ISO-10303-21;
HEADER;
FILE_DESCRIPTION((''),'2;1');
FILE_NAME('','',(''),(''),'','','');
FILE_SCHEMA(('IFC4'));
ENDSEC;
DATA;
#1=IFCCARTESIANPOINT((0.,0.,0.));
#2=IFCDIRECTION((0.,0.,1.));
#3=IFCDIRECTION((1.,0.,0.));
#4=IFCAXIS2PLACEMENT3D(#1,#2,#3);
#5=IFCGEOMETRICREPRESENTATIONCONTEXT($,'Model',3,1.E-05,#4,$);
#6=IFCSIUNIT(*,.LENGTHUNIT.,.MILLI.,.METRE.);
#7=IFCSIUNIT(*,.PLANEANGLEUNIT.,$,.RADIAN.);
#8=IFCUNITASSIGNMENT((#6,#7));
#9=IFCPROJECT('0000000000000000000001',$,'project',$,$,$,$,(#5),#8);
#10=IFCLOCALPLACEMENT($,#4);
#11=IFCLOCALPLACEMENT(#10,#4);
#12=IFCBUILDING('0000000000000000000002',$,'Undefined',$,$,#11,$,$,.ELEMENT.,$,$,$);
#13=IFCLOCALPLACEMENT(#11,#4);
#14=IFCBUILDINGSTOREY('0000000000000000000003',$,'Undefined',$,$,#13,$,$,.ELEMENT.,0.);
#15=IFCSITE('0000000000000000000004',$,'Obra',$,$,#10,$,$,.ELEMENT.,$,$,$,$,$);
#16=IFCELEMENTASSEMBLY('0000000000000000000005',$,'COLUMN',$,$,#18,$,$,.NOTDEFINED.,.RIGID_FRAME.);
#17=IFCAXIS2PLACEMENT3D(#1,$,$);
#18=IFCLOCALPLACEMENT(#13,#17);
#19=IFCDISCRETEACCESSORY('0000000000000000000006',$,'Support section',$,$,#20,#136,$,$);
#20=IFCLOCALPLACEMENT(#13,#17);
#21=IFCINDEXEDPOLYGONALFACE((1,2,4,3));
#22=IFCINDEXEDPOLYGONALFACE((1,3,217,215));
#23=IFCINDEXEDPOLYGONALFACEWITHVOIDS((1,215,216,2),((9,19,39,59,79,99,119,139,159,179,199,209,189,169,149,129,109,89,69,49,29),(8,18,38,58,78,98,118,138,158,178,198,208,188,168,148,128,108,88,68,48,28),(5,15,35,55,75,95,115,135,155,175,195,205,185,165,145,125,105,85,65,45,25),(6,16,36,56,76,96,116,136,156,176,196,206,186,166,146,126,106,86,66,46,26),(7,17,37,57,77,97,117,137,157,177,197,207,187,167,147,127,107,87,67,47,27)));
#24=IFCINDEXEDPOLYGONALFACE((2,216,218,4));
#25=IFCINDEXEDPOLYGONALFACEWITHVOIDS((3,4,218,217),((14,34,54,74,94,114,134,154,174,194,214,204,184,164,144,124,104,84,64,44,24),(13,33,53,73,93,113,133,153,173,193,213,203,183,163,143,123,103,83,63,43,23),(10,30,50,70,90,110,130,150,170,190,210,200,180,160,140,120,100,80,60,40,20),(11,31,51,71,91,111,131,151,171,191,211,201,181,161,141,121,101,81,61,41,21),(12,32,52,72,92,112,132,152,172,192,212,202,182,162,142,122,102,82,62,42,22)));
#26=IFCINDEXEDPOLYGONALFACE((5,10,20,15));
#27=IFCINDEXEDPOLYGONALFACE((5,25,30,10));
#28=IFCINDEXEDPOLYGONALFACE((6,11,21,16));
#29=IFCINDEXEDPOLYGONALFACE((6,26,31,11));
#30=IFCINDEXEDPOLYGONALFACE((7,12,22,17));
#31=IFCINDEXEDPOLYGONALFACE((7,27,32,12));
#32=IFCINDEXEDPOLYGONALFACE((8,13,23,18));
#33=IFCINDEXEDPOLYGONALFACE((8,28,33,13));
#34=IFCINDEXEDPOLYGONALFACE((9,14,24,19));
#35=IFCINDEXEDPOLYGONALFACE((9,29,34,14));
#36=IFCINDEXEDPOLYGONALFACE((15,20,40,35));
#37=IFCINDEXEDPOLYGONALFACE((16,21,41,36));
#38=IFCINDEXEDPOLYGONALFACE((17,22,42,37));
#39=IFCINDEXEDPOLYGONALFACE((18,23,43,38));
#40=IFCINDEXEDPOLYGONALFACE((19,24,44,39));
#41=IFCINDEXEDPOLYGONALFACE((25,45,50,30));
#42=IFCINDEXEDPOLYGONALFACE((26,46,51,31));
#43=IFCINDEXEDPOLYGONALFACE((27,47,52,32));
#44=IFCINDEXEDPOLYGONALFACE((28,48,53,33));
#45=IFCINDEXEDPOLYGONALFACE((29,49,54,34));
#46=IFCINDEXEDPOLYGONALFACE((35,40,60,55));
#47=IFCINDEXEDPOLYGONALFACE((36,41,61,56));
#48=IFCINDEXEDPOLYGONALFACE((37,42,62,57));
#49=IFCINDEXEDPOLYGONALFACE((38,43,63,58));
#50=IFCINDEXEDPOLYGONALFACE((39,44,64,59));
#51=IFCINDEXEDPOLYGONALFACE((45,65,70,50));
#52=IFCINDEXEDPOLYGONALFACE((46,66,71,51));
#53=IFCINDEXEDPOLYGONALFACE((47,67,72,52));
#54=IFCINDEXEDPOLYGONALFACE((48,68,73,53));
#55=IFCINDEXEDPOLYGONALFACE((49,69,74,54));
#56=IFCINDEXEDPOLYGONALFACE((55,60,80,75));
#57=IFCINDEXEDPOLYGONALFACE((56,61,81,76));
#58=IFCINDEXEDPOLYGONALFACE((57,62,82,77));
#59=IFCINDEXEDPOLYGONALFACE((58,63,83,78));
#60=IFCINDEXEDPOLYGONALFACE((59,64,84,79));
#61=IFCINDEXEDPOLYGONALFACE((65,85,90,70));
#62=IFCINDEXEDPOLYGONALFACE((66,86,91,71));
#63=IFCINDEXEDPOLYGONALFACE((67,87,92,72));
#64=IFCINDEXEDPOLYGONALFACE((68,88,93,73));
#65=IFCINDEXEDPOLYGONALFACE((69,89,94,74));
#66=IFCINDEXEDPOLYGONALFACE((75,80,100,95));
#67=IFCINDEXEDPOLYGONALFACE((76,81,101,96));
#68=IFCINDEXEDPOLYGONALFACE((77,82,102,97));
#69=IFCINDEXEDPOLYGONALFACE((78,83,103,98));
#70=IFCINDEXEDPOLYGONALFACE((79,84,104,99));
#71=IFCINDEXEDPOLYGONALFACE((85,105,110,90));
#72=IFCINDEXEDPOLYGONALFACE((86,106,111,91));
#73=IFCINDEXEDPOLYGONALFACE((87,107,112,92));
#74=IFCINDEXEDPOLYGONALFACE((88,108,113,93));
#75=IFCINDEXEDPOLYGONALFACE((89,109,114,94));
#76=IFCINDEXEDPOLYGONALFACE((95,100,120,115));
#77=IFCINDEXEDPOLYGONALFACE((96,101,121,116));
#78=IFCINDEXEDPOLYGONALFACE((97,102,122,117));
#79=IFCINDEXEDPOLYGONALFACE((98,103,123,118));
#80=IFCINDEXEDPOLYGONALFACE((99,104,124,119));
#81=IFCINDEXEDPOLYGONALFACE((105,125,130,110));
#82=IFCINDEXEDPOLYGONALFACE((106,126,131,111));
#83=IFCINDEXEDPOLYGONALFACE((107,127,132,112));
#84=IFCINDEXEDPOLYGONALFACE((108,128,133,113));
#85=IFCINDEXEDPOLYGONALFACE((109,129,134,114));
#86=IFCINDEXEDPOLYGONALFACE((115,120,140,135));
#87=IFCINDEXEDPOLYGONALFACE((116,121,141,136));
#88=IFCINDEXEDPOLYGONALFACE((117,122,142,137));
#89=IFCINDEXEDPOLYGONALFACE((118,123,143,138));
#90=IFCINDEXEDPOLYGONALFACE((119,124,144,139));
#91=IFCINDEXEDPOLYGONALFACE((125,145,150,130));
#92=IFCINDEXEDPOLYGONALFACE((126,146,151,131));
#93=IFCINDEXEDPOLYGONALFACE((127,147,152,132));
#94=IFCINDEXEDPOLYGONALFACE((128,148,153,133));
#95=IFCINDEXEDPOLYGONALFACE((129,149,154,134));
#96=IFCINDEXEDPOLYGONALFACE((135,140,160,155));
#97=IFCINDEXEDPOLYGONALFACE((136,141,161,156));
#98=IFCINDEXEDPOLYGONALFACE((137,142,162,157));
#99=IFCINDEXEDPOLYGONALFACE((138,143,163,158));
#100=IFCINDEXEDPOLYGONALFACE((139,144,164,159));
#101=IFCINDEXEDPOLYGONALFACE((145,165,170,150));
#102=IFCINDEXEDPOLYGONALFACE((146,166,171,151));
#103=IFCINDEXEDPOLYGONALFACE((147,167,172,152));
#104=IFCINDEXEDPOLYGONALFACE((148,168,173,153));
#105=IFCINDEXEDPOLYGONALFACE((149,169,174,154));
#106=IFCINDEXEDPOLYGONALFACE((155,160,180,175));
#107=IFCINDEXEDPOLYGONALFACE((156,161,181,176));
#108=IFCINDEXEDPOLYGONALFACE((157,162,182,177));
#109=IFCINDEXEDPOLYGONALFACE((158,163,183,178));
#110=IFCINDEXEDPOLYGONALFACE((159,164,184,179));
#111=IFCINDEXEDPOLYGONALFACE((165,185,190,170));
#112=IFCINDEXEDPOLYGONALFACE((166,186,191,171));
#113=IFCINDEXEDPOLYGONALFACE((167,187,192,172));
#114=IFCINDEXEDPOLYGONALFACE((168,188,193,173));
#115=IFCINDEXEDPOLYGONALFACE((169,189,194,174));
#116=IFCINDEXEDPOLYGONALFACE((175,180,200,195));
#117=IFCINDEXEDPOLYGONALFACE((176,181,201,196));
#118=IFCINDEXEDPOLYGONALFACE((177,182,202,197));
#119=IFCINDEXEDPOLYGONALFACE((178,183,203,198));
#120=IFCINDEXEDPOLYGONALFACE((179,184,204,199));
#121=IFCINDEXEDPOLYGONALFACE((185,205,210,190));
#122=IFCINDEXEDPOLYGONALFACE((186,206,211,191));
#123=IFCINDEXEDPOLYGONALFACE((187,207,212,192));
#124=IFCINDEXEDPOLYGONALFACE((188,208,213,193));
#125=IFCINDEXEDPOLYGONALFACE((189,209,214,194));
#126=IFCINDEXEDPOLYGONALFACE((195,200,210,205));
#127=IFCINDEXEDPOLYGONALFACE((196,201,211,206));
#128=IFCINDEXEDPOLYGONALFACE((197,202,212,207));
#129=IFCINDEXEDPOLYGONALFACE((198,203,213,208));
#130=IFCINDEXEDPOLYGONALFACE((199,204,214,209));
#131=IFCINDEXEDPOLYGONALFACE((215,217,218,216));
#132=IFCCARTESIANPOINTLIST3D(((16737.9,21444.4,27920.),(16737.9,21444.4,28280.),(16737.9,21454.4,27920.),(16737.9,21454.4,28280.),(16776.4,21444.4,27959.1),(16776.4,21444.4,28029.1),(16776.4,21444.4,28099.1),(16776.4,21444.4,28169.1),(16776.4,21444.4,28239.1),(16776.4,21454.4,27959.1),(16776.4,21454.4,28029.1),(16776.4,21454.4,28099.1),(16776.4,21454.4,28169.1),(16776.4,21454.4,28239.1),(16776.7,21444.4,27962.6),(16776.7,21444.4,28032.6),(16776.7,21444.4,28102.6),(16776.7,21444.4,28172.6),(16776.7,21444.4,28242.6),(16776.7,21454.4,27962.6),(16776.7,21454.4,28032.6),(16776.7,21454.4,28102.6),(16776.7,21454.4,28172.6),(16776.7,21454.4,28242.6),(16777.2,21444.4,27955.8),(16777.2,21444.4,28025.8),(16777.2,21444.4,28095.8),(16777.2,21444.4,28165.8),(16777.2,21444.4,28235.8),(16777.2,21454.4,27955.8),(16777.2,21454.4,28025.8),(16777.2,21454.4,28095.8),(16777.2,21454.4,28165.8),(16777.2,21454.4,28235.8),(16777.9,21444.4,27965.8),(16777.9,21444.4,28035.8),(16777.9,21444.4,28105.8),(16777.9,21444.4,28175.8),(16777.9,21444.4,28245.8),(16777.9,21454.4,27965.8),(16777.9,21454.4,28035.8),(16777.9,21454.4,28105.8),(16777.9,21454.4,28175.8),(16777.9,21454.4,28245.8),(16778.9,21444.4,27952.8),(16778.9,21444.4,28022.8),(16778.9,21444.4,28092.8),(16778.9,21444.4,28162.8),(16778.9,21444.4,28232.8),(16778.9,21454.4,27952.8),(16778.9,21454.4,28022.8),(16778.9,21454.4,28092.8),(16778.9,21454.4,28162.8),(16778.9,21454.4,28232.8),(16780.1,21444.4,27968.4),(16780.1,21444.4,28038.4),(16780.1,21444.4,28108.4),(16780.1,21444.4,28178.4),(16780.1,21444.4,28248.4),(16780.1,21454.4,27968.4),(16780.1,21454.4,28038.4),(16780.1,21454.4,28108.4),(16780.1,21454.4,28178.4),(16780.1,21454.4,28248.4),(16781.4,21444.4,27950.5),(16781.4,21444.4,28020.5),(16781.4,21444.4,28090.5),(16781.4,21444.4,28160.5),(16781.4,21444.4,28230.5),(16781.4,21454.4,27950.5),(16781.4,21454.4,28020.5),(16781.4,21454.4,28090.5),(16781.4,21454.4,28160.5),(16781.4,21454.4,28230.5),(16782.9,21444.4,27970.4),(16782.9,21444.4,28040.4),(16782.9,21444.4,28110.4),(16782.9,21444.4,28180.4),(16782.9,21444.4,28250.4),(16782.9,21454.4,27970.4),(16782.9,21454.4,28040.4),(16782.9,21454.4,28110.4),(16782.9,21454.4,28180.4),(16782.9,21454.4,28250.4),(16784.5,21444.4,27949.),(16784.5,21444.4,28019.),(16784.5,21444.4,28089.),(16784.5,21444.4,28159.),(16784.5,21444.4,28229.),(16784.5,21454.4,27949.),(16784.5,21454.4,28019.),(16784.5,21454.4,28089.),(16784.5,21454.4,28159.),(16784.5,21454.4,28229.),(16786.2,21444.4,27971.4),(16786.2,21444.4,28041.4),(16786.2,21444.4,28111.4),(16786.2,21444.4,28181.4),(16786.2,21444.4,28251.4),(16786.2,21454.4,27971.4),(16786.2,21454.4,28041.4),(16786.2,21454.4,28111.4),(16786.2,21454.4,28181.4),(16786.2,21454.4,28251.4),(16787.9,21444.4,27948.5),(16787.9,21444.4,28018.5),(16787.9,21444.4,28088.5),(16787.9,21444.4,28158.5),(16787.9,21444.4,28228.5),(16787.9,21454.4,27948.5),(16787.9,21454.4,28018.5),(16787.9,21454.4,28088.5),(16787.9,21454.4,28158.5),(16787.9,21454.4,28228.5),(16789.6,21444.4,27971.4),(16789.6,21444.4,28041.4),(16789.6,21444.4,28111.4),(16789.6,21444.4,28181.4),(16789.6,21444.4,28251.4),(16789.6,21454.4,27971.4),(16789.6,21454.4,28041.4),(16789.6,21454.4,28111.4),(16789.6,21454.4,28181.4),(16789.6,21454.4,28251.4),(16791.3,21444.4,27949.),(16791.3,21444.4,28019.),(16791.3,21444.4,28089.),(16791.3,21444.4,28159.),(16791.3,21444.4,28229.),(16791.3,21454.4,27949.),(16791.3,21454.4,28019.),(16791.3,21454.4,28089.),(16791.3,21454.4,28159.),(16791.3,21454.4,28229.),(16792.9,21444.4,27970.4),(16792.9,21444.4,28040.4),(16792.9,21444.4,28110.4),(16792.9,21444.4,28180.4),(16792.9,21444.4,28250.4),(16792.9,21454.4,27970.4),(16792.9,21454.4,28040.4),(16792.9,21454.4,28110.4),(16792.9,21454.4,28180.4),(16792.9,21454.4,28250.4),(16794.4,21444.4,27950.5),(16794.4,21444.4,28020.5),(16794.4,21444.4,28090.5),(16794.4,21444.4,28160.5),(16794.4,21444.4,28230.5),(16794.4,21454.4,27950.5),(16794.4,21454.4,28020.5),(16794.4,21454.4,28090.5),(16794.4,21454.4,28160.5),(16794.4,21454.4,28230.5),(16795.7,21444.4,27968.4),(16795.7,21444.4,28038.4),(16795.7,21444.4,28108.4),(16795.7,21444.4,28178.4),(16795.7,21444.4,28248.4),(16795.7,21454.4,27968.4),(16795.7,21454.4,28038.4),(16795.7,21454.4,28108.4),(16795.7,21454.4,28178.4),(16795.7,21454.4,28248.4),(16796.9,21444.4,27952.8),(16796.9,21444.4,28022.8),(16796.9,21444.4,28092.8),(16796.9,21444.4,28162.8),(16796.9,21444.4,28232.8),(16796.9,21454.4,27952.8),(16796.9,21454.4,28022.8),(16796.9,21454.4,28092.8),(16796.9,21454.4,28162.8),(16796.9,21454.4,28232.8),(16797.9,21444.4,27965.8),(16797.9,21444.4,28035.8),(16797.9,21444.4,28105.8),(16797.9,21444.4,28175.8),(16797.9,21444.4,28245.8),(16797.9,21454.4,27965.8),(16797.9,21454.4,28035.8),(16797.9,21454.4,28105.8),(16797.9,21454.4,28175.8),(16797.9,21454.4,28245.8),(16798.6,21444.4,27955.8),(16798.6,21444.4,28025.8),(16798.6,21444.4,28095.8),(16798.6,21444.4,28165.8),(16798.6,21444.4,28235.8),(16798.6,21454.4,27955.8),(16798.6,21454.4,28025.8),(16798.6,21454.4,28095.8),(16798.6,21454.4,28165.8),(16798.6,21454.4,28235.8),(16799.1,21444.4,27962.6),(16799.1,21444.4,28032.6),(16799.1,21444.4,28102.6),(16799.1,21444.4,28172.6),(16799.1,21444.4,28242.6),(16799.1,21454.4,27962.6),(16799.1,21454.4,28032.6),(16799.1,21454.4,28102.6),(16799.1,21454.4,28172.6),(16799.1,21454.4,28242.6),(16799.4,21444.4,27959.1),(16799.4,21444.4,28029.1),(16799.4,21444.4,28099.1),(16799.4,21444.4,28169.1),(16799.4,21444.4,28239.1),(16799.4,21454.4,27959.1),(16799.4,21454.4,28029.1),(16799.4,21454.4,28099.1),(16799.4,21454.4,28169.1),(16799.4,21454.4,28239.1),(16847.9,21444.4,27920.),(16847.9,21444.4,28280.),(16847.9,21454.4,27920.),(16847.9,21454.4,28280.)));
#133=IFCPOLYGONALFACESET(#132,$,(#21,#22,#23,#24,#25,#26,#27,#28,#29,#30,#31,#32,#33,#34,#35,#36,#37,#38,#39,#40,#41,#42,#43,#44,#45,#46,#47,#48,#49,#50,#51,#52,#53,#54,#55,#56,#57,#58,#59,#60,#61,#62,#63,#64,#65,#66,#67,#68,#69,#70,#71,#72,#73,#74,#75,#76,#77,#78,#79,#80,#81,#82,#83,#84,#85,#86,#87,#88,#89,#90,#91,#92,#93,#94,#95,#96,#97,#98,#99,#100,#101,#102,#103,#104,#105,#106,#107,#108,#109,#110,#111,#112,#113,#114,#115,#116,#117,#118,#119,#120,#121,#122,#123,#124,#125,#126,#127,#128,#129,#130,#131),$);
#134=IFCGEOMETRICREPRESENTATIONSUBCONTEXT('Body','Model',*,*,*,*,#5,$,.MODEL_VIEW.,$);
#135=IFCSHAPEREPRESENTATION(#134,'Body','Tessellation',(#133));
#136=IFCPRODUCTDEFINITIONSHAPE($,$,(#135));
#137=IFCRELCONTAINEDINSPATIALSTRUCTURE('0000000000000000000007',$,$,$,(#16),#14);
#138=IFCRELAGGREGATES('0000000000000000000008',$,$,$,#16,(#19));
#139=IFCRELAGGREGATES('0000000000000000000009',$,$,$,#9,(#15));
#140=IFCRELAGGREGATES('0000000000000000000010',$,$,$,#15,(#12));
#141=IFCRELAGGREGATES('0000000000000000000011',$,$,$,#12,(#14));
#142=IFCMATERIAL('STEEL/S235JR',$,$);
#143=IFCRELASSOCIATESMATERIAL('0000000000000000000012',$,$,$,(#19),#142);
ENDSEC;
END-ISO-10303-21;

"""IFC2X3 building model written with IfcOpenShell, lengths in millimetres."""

from ifc_helpers import new_model, si_unit, frame, origin_with_axes, origin_2d_with_axis, place, context, subcontext, project, spatial, rectangle, circle, extrude, source, transform, mapped, material, element, aggregate, save


model = new_model("IFC2X3")

# Units and contexts
model_context = context("Model", 3, precision=1e-05, world=origin_with_axes())
body_context = subcontext(model_context, "Body", "Model", "MODEL_VIEW")
ifc_project = project(units=[si_unit("LENGTHUNIT", "METRE", prefix="MILLI"), si_unit("PLANEANGLEUNIT", "RADIAN")], contexts=[model_context])

# Site, building, storey
site_placement = place(None, origin_with_axes())
site = spatial("IfcSite", under=ifc_project, at=site_placement, Name="Obra", CompositionType="ELEMENT")
building_placement = place(site_placement, origin_with_axes())
building = spatial("IfcBuilding", under=site, at=building_placement, Name="Undefined", CompositionType="ELEMENT")
storey_placement = place(building_placement, origin_with_axes())
storey = spatial("IfcBuildingStorey", under=building, at=storey_placement, Name="Undefined", CompositionType="ELEMENT", Elevation=0.0)

# Element assembly
assembly_1_placement = place(storey_placement, origin_with_axes())
assembly_1 = element("IfcElementAssembly", 1, at=assembly_1_placement, inside=storey, Name="COLUMN", AssemblyPlace="NOTDEFINED", PredefinedType="RIGID_FRAME")
ifc_material_1 = material(Name="STEEL/S235JR")

# Shared definitions
shared_shape_1 = source(origin_with_axes(), body_context, "Body", "SweptSolid", [
    extrude(circle(Radius=11.5, at=origin_2d_with_axis()), frame((0.0, -14.4, 0.0), z_axis=(0.0, 1.0, 0.0), x_axis=(1.0, 0.0, 0.0)), (0.0, 0.0, 1.0), 10.2),
])

# Discrete accessory, opening
discrete_accessory_1_placement = place(assembly_1_placement, frame((16792.9, 21449.4, 27920.0), z_axis=(0.0, 0.0, 1.0), x_axis=(1.0, 0.0, 0.0)))
discrete_accessory_1 = element("IfcDiscreteAccessory", 2, at=discrete_accessory_1_placement, material=ifc_material_1, Name="Support section", context=body_context, shape_type="SweptSolid", body=[
    extrude(rectangle(XDim=10.0, YDim=110.0, at=origin_2d_with_axis()), frame((0.0, 0.0, 360.0), z_axis=(0.0, 0.0, -1.0), x_axis=(0.0, 1.0, 0.0)), (0.0, 0.0, 1.0), 360.0),
])
opening_1_placement = place(assembly_1_placement, frame((16837.9, 21440.1, 28300.0), z_axis=(-1.0, 0.0, 0.0), x_axis=(0.0, 0.0, -1.0)))
element("IfcOpeningElement", 3, at=opening_1_placement, cuts=discrete_accessory_1, ObjectType="Opening", context=body_context, shape_type="MappedRepresentation", body=[
    mapped(shared_shape_1, transform((60.0, 0.0, 50.0))),
    mapped(shared_shape_1, transform((130.0, 0.0, 50.0))),
    mapped(shared_shape_1, transform((200.0, 0.0, 50.0))),
    mapped(shared_shape_1, transform((270.0, 0.0, 50.0))),
    mapped(shared_shape_1, transform((340.0, 0.0, 50.0))),
])
aggregate(assembly_1, [discrete_accessory_1])

save(model, "model.ifc")
